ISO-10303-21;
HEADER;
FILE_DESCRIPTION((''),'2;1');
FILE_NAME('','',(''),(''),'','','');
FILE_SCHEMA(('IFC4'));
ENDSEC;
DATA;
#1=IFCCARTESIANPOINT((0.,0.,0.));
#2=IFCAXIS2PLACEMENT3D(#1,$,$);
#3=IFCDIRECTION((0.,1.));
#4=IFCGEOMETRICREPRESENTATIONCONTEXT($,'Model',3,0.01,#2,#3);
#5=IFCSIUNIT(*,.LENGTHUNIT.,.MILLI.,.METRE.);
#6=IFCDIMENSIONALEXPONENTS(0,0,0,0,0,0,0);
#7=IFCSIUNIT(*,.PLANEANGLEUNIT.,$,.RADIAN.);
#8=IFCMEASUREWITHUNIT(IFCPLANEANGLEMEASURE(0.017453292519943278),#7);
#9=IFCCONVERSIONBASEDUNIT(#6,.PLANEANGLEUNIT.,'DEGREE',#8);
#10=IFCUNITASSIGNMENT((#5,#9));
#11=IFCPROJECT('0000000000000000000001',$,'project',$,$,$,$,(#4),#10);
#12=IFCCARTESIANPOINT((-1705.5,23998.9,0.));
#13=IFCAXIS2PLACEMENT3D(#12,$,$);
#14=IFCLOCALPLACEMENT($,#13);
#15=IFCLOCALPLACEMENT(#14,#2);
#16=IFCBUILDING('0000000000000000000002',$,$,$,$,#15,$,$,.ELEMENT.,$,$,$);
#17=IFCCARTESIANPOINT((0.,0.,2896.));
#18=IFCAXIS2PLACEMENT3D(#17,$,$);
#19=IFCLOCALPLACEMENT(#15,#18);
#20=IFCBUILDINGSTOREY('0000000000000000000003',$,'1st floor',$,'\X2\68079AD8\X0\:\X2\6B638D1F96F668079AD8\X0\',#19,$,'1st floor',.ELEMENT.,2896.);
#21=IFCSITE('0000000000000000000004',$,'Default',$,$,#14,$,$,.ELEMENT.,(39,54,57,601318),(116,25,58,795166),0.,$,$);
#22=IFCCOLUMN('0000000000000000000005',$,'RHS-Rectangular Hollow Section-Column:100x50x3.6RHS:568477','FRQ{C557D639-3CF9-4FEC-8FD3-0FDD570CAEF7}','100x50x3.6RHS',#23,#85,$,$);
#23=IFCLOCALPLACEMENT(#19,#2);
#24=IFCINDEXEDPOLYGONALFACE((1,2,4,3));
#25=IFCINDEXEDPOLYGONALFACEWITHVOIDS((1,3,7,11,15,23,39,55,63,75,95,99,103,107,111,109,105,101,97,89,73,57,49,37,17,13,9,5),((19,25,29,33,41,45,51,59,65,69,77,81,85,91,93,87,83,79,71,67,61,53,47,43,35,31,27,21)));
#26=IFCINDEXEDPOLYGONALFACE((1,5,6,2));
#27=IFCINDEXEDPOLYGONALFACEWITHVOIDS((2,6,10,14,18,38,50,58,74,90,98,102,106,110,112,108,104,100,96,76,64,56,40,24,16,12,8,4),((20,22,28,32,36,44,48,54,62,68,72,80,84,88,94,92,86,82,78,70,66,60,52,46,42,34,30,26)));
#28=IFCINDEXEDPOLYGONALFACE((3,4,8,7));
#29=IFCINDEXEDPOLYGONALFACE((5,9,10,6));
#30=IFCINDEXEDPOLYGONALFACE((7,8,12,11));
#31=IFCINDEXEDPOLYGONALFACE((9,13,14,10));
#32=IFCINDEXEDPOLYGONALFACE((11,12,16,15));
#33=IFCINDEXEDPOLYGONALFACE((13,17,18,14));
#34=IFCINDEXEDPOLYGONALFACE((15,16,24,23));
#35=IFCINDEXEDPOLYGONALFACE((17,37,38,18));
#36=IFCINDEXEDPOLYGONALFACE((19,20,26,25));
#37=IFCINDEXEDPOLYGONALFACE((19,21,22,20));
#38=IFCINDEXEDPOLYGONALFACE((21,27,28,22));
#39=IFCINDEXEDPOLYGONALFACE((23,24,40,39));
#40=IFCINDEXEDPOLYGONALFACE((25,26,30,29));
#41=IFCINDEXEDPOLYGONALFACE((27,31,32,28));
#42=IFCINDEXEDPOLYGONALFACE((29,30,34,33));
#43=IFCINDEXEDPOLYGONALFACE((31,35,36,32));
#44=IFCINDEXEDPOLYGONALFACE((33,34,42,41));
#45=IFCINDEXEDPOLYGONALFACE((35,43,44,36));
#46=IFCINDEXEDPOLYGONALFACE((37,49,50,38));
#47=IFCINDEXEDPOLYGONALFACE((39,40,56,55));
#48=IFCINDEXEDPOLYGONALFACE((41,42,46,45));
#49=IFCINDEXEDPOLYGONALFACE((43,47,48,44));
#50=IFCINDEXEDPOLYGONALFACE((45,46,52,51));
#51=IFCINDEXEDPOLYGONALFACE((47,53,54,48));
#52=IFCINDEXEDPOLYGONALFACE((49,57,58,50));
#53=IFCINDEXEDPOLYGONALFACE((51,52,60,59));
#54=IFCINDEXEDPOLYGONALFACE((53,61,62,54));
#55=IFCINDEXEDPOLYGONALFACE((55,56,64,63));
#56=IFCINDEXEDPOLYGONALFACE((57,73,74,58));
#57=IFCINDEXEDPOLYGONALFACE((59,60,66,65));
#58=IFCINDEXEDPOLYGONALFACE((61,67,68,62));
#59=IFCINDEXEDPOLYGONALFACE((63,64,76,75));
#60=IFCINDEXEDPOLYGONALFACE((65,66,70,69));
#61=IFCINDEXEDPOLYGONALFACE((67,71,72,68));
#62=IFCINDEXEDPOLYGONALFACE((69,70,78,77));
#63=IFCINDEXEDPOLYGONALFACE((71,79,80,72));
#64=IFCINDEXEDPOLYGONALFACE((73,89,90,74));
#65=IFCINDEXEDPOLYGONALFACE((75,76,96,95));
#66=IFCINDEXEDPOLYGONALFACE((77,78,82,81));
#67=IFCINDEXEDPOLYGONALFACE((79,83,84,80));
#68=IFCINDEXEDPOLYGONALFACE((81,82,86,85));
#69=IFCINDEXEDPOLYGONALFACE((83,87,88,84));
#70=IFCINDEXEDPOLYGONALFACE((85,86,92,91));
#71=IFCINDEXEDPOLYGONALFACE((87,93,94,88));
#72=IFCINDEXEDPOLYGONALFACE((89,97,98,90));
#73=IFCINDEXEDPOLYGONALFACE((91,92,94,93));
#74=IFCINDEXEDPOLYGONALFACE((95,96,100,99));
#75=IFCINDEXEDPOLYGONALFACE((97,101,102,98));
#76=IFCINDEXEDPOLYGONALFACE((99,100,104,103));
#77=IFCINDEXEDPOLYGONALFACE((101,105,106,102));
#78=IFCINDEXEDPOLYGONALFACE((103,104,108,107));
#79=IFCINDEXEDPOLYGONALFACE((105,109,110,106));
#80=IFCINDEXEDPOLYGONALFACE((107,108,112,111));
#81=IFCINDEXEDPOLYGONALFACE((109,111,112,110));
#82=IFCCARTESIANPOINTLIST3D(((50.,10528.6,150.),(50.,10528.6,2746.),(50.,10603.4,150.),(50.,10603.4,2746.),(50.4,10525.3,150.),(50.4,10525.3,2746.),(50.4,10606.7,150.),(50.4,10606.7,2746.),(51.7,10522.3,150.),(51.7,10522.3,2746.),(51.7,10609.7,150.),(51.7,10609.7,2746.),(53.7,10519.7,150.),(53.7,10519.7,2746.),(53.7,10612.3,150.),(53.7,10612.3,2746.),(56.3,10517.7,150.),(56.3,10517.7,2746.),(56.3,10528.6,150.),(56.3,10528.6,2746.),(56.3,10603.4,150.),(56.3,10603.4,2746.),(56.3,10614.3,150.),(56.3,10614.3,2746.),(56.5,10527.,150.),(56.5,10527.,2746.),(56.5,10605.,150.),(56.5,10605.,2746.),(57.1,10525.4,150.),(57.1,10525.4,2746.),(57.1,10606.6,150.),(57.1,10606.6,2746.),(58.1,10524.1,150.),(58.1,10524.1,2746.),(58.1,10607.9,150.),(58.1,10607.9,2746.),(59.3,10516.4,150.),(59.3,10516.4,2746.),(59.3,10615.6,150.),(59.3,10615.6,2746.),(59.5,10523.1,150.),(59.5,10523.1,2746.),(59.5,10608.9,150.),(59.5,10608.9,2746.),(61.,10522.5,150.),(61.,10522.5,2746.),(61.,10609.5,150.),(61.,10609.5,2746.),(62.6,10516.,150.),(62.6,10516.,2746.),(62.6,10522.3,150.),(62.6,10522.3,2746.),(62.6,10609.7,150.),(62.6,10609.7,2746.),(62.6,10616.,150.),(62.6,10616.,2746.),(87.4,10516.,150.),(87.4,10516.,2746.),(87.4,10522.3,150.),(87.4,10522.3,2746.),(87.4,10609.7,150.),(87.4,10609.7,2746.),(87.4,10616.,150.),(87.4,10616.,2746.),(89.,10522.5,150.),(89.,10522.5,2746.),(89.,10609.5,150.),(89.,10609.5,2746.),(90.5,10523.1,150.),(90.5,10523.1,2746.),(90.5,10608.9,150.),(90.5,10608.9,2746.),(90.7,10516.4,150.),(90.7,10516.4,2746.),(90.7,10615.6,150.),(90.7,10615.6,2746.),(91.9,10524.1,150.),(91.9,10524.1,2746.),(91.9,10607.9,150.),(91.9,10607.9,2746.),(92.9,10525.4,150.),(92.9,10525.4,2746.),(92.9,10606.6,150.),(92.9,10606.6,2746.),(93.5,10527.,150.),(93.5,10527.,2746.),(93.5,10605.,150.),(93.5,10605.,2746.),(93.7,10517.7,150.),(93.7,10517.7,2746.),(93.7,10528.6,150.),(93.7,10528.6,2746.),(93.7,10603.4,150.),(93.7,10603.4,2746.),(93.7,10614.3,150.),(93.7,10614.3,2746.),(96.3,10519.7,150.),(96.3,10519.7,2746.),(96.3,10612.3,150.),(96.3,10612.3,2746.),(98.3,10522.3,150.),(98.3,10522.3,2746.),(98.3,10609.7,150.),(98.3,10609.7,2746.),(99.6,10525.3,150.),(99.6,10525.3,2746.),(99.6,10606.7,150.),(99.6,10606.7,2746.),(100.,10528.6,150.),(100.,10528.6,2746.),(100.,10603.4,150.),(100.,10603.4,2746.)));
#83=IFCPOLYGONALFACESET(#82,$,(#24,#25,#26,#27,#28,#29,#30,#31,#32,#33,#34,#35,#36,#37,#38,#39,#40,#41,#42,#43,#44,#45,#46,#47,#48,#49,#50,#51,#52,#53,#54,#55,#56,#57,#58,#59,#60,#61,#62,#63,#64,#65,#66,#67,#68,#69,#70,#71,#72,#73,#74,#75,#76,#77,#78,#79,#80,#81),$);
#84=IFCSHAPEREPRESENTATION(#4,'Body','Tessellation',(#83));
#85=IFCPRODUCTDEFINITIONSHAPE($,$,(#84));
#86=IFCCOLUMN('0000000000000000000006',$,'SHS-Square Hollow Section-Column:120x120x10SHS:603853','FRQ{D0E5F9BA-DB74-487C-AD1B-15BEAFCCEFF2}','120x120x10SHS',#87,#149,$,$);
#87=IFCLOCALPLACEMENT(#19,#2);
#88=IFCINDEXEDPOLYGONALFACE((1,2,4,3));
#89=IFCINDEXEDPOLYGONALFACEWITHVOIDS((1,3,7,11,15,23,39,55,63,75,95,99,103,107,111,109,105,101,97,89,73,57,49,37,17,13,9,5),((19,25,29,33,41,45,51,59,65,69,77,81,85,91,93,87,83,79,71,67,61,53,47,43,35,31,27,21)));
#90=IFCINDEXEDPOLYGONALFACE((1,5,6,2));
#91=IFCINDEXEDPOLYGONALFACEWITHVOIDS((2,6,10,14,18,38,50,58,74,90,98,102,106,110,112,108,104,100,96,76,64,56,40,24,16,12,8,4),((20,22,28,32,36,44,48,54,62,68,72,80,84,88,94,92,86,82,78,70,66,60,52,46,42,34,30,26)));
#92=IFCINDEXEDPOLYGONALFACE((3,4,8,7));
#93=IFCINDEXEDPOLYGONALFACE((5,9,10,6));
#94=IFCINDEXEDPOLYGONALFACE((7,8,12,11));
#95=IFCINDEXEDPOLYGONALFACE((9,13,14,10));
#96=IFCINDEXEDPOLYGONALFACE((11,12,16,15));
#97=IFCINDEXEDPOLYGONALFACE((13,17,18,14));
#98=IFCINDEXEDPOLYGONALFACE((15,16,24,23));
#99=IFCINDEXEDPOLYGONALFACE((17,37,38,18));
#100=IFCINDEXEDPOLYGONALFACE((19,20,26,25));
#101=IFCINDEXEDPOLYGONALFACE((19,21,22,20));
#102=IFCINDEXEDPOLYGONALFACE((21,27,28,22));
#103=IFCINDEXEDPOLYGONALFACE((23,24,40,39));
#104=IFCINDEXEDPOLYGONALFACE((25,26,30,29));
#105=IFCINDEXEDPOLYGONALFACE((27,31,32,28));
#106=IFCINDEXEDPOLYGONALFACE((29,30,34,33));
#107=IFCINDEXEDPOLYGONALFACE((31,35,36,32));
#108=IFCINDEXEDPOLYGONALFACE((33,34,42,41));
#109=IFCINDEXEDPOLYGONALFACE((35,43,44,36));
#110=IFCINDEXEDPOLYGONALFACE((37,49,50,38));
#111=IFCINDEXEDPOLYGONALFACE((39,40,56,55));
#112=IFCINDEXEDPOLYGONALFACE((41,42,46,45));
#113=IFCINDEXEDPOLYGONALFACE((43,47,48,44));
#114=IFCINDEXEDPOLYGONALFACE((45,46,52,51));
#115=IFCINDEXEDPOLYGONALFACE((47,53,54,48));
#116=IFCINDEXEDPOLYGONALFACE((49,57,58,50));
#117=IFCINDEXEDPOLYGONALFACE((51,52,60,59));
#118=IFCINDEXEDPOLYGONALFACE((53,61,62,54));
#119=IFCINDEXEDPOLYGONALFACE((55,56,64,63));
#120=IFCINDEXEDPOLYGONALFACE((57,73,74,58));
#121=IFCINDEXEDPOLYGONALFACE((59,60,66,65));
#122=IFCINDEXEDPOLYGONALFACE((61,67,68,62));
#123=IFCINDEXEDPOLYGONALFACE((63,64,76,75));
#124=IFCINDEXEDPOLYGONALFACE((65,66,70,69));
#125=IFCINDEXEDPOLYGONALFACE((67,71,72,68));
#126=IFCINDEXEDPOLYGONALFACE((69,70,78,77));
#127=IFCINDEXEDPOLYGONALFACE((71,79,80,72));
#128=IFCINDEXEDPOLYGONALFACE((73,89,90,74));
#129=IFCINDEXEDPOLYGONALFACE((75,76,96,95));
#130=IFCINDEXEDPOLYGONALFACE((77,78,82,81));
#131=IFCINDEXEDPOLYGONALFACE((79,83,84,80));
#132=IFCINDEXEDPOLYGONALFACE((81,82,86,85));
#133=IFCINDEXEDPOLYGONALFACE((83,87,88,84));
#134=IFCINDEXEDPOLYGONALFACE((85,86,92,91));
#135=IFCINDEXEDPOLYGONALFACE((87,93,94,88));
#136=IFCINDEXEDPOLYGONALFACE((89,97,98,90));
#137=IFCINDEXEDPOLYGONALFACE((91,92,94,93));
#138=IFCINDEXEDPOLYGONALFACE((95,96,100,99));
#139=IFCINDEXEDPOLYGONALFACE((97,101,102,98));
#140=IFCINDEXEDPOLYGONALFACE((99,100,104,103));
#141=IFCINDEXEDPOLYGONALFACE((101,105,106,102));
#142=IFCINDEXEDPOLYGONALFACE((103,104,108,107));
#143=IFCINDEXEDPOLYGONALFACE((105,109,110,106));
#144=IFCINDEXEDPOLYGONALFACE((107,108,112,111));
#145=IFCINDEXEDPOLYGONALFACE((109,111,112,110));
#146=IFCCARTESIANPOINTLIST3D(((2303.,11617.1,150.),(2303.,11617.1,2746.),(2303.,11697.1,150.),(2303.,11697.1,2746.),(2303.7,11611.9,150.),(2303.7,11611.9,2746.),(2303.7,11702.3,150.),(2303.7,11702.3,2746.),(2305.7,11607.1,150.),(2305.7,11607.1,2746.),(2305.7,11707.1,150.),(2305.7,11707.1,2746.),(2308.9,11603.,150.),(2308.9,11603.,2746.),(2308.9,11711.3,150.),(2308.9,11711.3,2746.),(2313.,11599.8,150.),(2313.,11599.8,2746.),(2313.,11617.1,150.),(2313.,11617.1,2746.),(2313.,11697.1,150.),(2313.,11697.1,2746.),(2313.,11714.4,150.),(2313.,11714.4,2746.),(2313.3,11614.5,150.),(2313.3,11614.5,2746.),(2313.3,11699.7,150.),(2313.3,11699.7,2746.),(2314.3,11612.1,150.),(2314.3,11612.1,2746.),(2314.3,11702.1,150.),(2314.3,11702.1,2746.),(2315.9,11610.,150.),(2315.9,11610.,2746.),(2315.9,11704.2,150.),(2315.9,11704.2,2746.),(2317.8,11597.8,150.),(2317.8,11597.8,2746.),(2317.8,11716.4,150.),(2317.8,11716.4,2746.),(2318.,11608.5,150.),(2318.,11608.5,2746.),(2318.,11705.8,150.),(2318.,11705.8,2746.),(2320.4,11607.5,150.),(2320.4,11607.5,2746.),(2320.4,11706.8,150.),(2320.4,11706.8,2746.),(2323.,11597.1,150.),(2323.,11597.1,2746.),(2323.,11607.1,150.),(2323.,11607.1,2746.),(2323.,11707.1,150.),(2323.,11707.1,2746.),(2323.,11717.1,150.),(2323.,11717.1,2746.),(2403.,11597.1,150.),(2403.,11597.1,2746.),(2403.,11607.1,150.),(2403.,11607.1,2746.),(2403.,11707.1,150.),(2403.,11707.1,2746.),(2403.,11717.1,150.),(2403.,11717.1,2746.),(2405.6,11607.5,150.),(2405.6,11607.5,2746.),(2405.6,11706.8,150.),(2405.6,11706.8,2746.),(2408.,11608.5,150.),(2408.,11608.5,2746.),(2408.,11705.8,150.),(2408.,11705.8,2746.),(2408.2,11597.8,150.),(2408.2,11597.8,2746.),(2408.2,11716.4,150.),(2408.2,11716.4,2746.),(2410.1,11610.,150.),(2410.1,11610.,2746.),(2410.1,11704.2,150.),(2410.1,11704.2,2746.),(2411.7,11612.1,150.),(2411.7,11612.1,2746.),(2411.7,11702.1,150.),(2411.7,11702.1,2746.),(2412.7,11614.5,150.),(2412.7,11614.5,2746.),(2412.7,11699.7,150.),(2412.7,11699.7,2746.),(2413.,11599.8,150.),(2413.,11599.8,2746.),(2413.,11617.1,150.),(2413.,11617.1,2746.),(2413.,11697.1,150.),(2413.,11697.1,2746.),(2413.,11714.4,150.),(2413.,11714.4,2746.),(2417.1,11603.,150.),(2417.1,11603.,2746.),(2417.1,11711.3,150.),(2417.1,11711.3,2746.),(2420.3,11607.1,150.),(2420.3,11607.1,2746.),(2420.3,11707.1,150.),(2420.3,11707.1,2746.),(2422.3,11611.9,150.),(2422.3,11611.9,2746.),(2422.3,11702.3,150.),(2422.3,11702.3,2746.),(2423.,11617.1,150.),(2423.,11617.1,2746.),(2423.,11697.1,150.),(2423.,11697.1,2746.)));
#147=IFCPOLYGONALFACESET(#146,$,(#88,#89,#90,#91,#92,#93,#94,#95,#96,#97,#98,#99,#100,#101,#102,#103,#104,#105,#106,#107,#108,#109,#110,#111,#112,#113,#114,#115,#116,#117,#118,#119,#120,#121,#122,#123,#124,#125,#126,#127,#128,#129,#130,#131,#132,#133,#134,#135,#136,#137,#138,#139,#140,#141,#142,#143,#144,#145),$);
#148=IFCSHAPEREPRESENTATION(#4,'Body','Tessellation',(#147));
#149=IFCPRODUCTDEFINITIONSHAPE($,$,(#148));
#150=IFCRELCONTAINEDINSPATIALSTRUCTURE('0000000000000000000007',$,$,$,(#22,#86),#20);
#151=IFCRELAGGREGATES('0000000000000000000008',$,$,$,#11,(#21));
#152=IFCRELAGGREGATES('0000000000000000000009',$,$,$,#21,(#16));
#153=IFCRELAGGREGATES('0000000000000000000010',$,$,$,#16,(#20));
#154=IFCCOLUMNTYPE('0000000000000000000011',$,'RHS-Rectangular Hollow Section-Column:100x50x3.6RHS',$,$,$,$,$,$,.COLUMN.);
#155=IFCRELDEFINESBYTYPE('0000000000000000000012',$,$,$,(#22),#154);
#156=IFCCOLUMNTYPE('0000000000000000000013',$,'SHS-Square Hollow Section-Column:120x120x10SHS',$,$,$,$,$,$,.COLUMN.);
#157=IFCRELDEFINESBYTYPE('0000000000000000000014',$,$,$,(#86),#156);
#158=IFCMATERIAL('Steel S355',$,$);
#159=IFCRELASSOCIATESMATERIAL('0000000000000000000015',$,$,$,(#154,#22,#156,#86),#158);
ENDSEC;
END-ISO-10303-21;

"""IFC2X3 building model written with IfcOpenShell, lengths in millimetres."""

from ifc_helpers import new_model, entity, si_unit, converted_unit, point, direction, frame, frame_2d, origin, origin_2d, place, context, project, spatial, circle_curve, line_curve, trimmed, segment, composite_curve, hollow_rectangle, outline, extrude, clip, halfspace, material, type_object, element, save


model = new_model("IFC2X3")

# Units and contexts
model_context = context("Model", 3, precision=0.01, world=origin(), true_north=direction((0.0, 1.0)))
ifc_project = project(units=[si_unit("LENGTHUNIT", "METRE", prefix="MILLI"), converted_unit("PLANEANGLEUNIT", "DEGREE", entity("IfcPlaneAngleMeasure", 0.017453292519943278), si_unit("PLANEANGLEUNIT", "RADIAN"), dimensions=[0, 0, 0, 0, 0, 0, 0])], contexts=[model_context])

# Site, building, storey
site_placement = place(None, frame((-1705.5, 23998.9, 0.0)))
site = spatial("IfcSite", under=ifc_project, at=site_placement, Name="Default", CompositionType="ELEMENT", RefLatitude=(39, 54, 57, 601318), RefLongitude=(116, 25, 58, 795166), RefElevation=0.0)
building_placement = place(site_placement, origin())
building = spatial("IfcBuilding", under=site, at=building_placement, CompositionType="ELEMENT")
storey_placement = place(building_placement, frame((0.0, 0.0, 2896.0)))
storey = spatial("IfcBuildingStorey", under=building, at=storey_placement, Name="1st floor", ObjectType="标高:正负零标高", LongName="1st floor", CompositionType="ELEMENT", Elevation=2896.0)

# Column, opening
ifc_material_1 = material(Name="Steel S355")
column_type_1 = type_object("IfcColumnType", Name="RHS-Rectangular Hollow Section-Column:100x50x3.6RHS", PredefinedType="COLUMN", material=ifc_material_1)
column_1_placement = place(storey_placement, frame((75.0, 10566.0, 2876.9)))
column_1 = element("IfcColumn", 1, at=column_1_placement, inside=storey, type_object=column_type_1, material=ifc_material_1, Name="RHS-Rectangular Hollow Section-Column:100x50x3.6RHS:568477", Description="FRQ{C557D639-3CF9-4FEC-8FD3-0FDD570CAEF7}", ObjectType="100x50x3.6RHS", context=model_context, shape_type="Clipping", body=[
    clip(clip(extrude(hollow_rectangle(XDim=50.0, YDim=100.0, WallThickness=6.3, InnerFilletRadius=6.3, OuterFilletRadius=12.6, at=origin_2d()), origin(), (0.0, 0.0, -1.0), 2782.8), halfspace(frame((-75.0, -10566.0, -2726.9), z_axis=(0.0, 0.0, 1.0), x_axis=(1.0, 0.0, 0.0)), True)), halfspace(frame((-75.0, -10566.0, -55.9), z_axis=(0.0, 0.0, -1.0), x_axis=(-1.0, 0.0, 0.0)), True)),
])
opening_1_placement = place(column_1_placement, frame((0.0, -150.1, -130.9), z_axis=(0.0, 1.0, 0.0), x_axis=(-1.0, 0.0, 0.0)))
element("IfcOpeningElement", 2, at=opening_1_placement, cuts=column_1, ObjectType="Opening", context=model_context, shape_type="SweptSolid", body=[
    extrude(outline(composite_curve([segment(trimmed(circle_curve(frame_2d((43.0, 32.0), x_axis=(1.0, 0.0)), 32.0), [point((43.0, 0.0))], [point((75.0, 32.0))], True, "CARTESIAN"), True, "CONTINUOUS"), segment(trimmed(line_curve((75.0, 32.0), (0.0, 1.0), 86.0), [point((75.0, 32.0))], [point((75.0, 118.0))], True, "CARTESIAN"), True, "CONTINUOUS"), segment(trimmed(circle_curve(frame_2d((43.0, 118.0), x_axis=(1.0, 0.0)), 32.0), [point((75.0, 118.0))], [point((43.0, 150.0))], True, "CARTESIAN"), True, "CONTINUOUS"), segment(trimmed(line_curve((43.0, 150.0), (-1.0, 0.0), 86.0), [point((43.0, 150.0))], [point((-43.0, 150.0))], True, "CARTESIAN"), True, "CONTINUOUS"), segment(trimmed(circle_curve(frame_2d((-43.0, 118.0), x_axis=(1.0, 0.0)), 32.0), [point((-43.0, 150.0))], [point((-75.0, 118.0))], True, "CARTESIAN"), True, "CONTINUOUS"), segment(trimmed(line_curve((-75.0, 118.0), (0.0, -1.0), 86.0), [point((-75.0, 118.0))], [point((-75.0, 32.0))], True, "CARTESIAN"), True, "CONTINUOUS"), segment(trimmed(circle_curve(frame_2d((-43.0, 32.0), x_axis=(1.0, 0.0)), 32.0), [point((-75.0, 32.0))], [point((-43.0, 0.0))], True, "CARTESIAN"), True, "CONTINUOUS"), segment(trimmed(line_curve((-43.0, 0.0), (1.0, 0.0), 86.0), [point((-43.0, 0.0))], [point((43.0, 0.0))], True, "CARTESIAN"), True, "CONTINUOUS")], self_intersect="UNKNOWN")), origin(), (0.0, 0.0, 1.0), 300.2),
])
column_type_2 = type_object("IfcColumnType", Name="SHS-Square Hollow Section-Column:120x120x10SHS", PredefinedType="COLUMN", material=ifc_material_1)

# Column
column_2_placement = place(storey_placement, frame((2363.0, 11657.1, 2746.0), z_axis=(0.0, 0.0, 1.0), x_axis=(0.0, 1.0, 0.0)))
element("IfcColumn", 3, at=column_2_placement, inside=storey, type_object=column_type_2, material=ifc_material_1, Name="SHS-Square Hollow Section-Column:120x120x10SHS:603853", Description="FRQ{D0E5F9BA-DB74-487C-AD1B-15BEAFCCEFF2}", ObjectType="120x120x10SHS", context=model_context, shape_type="Clipping", body=[
    clip(extrude(hollow_rectangle(XDim=120.0, YDim=120.0, WallThickness=10.0, InnerFilletRadius=10.0, OuterFilletRadius=20.0, at=origin_2d()), origin(), (0.0, 0.0, -1.0), 2680.9), halfspace(frame((-11657.1, 2363.0, -2596.0), z_axis=(0.0, 0.0, 1.0), x_axis=(0.0, -1.0, 0.0)), True)),
])

save(model, "model.ifc")
